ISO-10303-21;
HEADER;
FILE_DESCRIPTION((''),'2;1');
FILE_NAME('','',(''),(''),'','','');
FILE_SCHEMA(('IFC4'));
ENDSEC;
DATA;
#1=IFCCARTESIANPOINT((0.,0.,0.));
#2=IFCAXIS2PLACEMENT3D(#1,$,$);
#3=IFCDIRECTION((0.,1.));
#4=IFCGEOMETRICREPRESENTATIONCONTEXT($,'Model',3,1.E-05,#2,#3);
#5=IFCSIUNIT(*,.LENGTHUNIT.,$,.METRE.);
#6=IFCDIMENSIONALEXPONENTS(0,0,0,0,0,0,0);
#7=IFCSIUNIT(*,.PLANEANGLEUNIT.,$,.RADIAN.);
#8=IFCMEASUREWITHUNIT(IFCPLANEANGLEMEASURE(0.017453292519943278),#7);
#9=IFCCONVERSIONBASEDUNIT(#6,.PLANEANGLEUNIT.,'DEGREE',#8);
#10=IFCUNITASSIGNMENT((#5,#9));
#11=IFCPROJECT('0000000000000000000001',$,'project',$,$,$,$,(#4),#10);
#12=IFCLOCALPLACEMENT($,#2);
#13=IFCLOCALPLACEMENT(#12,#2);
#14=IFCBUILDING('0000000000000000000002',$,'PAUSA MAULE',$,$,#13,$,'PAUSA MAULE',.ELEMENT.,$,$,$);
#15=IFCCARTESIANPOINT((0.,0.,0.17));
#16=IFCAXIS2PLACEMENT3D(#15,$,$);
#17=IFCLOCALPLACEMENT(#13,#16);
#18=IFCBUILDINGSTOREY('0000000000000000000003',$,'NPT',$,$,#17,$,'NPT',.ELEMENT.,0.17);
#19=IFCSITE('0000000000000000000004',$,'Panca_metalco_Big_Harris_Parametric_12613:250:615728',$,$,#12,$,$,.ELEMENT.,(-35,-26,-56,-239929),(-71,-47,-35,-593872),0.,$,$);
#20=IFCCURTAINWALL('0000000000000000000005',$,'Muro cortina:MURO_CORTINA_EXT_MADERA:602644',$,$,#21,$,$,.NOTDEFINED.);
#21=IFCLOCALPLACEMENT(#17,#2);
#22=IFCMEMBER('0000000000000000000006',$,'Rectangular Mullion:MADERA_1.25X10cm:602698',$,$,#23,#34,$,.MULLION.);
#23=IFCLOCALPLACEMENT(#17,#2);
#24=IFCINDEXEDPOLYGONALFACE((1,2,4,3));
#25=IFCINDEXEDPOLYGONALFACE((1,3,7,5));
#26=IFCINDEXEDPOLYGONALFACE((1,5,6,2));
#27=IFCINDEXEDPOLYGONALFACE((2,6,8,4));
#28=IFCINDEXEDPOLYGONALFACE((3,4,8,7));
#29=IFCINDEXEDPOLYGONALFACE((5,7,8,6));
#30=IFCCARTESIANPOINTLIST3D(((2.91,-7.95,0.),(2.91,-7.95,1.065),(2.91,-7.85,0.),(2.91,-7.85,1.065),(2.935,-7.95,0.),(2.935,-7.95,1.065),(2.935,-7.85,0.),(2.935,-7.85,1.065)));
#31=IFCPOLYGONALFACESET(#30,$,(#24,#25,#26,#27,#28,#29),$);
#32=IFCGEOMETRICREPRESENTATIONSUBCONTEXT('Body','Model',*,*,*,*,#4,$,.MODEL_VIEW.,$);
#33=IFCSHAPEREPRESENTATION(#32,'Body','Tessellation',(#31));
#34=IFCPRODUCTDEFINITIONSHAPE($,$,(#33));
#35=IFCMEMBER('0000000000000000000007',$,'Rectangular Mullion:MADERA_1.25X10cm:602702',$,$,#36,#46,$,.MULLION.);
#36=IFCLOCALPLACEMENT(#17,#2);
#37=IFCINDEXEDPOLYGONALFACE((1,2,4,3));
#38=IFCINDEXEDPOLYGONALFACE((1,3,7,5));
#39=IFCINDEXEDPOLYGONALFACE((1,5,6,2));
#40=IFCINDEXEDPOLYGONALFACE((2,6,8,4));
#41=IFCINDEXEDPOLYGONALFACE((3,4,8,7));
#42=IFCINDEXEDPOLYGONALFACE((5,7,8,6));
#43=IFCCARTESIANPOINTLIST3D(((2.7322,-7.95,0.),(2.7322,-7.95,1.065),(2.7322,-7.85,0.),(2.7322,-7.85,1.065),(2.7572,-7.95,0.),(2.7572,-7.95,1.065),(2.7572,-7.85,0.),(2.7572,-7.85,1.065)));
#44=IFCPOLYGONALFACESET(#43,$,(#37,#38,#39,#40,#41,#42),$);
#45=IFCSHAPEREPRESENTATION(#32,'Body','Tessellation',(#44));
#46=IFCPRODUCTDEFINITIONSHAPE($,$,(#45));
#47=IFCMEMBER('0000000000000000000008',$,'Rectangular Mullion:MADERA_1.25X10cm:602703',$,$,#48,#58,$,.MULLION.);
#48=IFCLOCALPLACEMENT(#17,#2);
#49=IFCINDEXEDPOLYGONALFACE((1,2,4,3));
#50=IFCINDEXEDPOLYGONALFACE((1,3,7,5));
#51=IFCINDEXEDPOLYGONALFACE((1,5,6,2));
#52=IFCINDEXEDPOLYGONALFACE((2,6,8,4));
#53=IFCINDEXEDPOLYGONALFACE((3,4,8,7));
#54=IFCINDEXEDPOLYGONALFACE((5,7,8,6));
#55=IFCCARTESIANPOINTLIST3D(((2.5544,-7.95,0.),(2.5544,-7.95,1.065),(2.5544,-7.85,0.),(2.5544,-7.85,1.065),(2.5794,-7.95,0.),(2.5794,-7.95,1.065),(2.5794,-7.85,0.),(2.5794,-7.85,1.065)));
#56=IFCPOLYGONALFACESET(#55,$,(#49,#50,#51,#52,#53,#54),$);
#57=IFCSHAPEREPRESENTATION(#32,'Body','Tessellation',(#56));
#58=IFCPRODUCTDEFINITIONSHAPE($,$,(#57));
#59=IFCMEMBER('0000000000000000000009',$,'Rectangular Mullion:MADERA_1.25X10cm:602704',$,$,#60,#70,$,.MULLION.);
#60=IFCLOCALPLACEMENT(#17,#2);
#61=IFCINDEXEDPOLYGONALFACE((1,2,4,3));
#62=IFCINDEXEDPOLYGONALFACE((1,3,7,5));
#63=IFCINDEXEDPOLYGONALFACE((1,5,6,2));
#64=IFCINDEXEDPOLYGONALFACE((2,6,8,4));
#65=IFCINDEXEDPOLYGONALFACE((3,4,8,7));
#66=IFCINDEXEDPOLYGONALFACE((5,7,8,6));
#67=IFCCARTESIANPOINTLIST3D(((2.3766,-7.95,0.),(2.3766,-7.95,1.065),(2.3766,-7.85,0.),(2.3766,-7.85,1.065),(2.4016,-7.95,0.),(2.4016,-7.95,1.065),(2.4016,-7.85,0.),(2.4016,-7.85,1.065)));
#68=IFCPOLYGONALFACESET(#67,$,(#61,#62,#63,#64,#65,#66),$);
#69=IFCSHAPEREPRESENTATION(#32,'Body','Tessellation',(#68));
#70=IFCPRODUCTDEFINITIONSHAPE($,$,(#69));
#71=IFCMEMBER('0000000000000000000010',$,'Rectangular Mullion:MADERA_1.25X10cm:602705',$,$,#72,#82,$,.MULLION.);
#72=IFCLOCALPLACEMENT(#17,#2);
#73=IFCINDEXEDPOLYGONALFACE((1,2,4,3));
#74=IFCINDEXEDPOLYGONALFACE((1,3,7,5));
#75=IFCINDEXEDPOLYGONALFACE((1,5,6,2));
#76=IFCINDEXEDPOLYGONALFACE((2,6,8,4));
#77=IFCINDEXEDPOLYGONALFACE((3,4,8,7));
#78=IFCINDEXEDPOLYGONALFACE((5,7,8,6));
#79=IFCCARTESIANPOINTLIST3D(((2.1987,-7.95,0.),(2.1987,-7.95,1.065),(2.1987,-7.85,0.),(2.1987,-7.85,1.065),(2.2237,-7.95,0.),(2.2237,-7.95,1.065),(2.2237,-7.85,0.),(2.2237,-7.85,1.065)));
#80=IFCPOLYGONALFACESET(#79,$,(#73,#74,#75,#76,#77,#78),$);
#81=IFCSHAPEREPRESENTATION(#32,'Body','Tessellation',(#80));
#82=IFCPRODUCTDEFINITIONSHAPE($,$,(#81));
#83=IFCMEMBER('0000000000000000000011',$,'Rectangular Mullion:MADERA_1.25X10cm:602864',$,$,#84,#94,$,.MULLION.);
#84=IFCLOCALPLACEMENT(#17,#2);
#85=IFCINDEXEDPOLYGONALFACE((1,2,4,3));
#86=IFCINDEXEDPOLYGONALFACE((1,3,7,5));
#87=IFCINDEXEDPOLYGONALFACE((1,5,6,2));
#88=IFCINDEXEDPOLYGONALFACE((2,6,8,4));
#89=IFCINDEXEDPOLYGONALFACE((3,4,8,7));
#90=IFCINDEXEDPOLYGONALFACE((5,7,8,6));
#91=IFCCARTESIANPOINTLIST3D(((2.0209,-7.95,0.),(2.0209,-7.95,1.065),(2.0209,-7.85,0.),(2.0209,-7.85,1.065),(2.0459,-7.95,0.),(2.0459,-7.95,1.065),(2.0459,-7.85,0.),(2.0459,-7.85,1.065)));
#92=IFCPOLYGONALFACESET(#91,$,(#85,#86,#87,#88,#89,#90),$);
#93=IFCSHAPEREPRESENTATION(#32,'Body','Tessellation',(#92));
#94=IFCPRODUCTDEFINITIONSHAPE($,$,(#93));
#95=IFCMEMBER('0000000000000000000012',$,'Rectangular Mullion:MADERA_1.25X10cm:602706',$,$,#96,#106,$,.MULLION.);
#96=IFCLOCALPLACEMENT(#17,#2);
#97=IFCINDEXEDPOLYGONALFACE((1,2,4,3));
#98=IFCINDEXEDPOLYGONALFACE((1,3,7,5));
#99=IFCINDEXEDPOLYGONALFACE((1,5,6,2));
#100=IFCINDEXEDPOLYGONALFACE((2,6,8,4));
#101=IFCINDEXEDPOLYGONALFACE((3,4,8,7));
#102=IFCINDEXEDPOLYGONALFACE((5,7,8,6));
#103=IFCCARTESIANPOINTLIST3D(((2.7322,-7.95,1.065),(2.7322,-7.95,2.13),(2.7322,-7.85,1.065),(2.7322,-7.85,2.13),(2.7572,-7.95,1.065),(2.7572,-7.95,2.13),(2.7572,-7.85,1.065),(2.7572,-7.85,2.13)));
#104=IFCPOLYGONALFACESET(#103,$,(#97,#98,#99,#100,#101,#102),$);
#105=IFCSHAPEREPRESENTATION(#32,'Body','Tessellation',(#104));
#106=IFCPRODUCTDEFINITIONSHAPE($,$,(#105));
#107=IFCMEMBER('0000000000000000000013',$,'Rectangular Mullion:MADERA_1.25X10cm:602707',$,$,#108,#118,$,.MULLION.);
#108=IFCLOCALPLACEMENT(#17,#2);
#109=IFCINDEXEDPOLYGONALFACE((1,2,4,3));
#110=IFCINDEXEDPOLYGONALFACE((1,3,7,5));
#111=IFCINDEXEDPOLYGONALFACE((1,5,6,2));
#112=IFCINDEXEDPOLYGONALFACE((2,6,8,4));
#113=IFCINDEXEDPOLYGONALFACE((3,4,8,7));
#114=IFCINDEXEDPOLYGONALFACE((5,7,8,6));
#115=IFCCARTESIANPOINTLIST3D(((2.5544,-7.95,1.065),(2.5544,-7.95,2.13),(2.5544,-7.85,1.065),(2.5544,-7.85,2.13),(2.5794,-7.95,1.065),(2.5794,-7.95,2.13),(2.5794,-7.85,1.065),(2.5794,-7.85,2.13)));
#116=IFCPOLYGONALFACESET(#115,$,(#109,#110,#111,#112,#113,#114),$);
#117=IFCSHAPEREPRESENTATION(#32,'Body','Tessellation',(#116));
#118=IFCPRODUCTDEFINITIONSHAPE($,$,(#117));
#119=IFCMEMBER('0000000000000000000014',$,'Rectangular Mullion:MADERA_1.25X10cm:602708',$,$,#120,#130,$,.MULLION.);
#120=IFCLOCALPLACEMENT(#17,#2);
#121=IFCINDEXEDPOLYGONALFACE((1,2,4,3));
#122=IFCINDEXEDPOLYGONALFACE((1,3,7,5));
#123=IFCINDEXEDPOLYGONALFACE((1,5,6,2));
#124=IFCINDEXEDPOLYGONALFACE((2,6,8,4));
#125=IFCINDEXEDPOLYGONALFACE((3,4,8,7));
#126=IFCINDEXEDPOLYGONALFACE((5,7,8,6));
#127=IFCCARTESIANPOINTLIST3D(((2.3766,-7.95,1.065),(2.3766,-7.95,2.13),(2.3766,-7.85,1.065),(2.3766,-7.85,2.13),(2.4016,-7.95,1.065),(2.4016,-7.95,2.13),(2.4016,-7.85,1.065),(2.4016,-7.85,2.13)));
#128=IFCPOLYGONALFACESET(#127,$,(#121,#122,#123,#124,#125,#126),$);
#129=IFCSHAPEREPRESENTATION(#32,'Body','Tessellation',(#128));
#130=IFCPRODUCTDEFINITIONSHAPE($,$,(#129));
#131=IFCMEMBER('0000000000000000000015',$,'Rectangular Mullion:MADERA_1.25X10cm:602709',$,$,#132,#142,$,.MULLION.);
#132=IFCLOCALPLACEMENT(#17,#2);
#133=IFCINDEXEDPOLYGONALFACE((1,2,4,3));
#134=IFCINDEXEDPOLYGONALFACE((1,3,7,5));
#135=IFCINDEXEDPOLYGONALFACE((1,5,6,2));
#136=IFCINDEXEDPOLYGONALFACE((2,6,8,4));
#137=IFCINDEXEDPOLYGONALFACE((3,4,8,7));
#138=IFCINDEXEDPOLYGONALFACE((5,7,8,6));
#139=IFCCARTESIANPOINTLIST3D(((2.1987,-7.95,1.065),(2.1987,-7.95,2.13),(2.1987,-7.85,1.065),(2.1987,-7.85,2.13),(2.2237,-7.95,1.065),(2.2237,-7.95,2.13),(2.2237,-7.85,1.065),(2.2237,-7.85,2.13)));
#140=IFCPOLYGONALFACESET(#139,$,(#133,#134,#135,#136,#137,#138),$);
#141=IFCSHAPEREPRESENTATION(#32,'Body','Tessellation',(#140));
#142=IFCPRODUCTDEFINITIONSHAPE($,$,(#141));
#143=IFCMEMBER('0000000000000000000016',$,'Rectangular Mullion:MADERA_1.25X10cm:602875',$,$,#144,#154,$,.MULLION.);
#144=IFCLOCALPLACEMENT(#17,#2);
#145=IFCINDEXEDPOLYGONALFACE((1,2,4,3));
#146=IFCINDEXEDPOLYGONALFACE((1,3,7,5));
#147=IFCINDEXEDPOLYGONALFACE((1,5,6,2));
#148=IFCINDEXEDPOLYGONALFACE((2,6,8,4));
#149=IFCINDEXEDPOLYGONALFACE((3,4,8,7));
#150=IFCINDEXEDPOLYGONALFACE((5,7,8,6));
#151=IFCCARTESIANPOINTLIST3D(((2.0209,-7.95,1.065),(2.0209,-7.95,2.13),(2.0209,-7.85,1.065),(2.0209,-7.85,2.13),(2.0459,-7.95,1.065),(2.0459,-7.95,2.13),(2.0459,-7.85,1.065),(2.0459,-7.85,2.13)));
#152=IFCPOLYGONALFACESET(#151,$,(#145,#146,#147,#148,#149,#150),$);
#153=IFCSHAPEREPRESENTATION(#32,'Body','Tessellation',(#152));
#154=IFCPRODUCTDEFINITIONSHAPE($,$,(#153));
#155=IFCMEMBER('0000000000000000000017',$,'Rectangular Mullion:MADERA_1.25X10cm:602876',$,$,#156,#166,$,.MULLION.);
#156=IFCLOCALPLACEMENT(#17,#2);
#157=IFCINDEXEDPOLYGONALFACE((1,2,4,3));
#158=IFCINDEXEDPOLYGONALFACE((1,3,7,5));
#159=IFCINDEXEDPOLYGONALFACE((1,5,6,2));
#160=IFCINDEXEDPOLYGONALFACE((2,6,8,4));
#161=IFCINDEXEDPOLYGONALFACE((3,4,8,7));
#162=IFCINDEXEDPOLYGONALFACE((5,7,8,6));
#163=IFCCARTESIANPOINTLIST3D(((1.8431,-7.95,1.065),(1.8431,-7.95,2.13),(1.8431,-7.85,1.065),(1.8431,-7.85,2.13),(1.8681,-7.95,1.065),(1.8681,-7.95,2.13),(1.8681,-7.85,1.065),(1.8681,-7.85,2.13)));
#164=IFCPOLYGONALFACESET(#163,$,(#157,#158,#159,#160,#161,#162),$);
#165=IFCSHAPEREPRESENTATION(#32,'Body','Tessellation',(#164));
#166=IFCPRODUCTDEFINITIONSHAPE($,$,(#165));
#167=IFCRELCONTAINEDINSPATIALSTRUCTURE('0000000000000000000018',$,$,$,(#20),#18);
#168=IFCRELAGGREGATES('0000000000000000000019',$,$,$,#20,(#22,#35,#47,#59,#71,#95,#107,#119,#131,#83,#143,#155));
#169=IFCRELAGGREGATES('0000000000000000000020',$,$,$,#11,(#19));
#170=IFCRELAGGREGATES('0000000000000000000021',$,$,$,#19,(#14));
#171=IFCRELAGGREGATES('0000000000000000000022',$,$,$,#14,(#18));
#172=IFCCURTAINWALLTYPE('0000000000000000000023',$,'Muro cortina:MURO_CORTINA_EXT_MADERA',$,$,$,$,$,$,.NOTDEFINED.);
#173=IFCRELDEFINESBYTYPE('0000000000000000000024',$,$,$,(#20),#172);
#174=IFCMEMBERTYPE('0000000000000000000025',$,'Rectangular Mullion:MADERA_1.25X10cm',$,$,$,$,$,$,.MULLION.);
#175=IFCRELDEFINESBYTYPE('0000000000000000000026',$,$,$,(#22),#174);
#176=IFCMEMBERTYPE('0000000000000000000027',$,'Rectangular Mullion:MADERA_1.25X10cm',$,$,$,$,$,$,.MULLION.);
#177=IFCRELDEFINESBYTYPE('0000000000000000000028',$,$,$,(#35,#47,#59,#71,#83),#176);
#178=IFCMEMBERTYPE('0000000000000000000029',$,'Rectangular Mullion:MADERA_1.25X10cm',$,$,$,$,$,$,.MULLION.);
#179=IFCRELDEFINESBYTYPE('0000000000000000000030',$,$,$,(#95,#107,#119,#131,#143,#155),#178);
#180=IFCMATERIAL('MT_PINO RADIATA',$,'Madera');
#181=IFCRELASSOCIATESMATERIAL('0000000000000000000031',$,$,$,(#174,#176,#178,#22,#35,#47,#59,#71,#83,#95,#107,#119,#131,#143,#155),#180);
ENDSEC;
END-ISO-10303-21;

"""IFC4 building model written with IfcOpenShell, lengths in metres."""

from ifc_helpers import new_model, entity, si_unit, converted_unit, direction, frame, frame_2d, origin, place, context, subcontext, project, spatial, rectangle, extrude, source, transform, mapped, material, material_profile, profile_set, profile_usage, type_object, type_shapes, element, aggregate, save


model = new_model("IFC4")

# Units and contexts
model_context = context("Model", 3, precision=1e-05, world=origin(), true_north=direction((0.0, 1.0)))
body_context = subcontext(model_context, "Body", "Model", "MODEL_VIEW")
ifc_project = project(units=[si_unit("LENGTHUNIT", "METRE"), converted_unit("PLANEANGLEUNIT", "DEGREE", entity("IfcPlaneAngleMeasure", 0.017453292519943278), si_unit("PLANEANGLEUNIT", "RADIAN"), dimensions=[0, 0, 0, 0, 0, 0, 0])], contexts=[model_context])

# Site, building, storey
site_placement = place(None, origin())
site = spatial("IfcSite", under=ifc_project, at=site_placement, Name="Panca_metalco_Big_Harris_Parametric_12613:250:615728", CompositionType="ELEMENT", RefLatitude=(-35, -26, -56, -239929), RefLongitude=(-71, -47, -35, -593872), RefElevation=0.0)
building_placement = place(site_placement, origin())
building = spatial("IfcBuilding", under=site, at=building_placement, Name="PAUSA MAULE", LongName="PAUSA MAULE", CompositionType="ELEMENT")
storey_placement = place(building_placement, frame((0.0, 0.0, 0.17)))
storey = spatial("IfcBuildingStorey", under=building, at=storey_placement, Name="NPT", LongName="NPT", CompositionType="ELEMENT", Elevation=0.17)

# Curtain wall, members
curtain_wall_type = type_object("IfcCurtainWallType", Name="Muro cortina:MURO_CORTINA_EXT_MADERA", PredefinedType="NOTDEFINED")
curtain_wall_placement = place(storey_placement, frame((0.0, 0.0, -0.17)))
curtain_wall = element("IfcCurtainWall", 1, at=curtain_wall_placement, inside=storey, type_object=curtain_wall_type, Name="Muro cortina:MURO_CORTINA_EXT_MADERA:602644", PredefinedType="NOTDEFINED")
ifc_material = material(Name="MT_PINO RADIATA", Category="Madera")
ifc_material_profile = material_profile(ifc_material, rectangle(XDim=0.025, YDim=0.1, at=frame_2d((0.0, 0.0), x_axis=(1.0, 0.0))), Name="MADERA_1.25X10cm")
ifc_profile_set = profile_set([ifc_material_profile], Name="MADERA_1.25X10cm")
ifc_profile_usage = profile_usage(ifc_profile_set)
member_type_1 = type_object("IfcMemberType", Name="Rectangular Mullion:MADERA_1.25X10cm", PredefinedType="MULLION", material=ifc_profile_set)
shared_shape_1 = source(origin(), body_context, "Body", "SweptSolid", [
    extrude(rectangle(XDim=0.025, YDim=0.1, at=frame_2d((0.0, 0.0), x_axis=(1.0, 0.0))), frame((-0.0125, 0.0, -1.065), z_axis=(0.0, 0.0, 1.0), x_axis=(-1.0, 0.0, 0.0)), (0.0, 0.0, 1.0), 1.065),
])
type_shapes(member_type_1, [shared_shape_1])
member_1_placement = place(curtain_wall_placement, frame((2.935, -7.9, 1.235)))
member_1 = element("IfcMember", 2, at=member_1_placement, type_object=member_type_1, material=ifc_profile_usage, Name="Rectangular Mullion:MADERA_1.25X10cm:602698", PredefinedType="MULLION", context=body_context, shape_type="MappedRepresentation", body=[
    mapped(shared_shape_1, transform((0.0, 0.0, 0.0), scale=1.0)),
])
member_type_2 = type_object("IfcMemberType", Name="Rectangular Mullion:MADERA_1.25X10cm", PredefinedType="MULLION", material=ifc_profile_set)
shared_shape_2 = source(origin(), body_context, "Body", "SweptSolid", [
    extrude(rectangle(XDim=0.025, YDim=0.1, at=frame_2d((0.0, 0.0), x_axis=(1.0, 0.0))), frame((0.0, 0.0, -1.065), z_axis=(0.0, 0.0, 1.0), x_axis=(-1.0, 0.0, 0.0)), (0.0, 0.0, 1.0), 1.065),
])
type_shapes(member_type_2, [shared_shape_2])
member_2_placement = place(curtain_wall_placement, frame((2.7447, -7.9, 0.17), z_axis=(0.0, 0.0, -1.0), x_axis=(-1.0, 0.0, 0.0)))
member_2 = element("IfcMember", 3, at=member_2_placement, type_object=member_type_2, material=ifc_profile_usage, Name="Rectangular Mullion:MADERA_1.25X10cm:602702", PredefinedType="MULLION", context=body_context, shape_type="MappedRepresentation", body=[
    mapped(shared_shape_2, transform((0.0, 0.0, 0.0), scale=1.0)),
])
member_3_placement = place(curtain_wall_placement, frame((2.5669, -7.9, 0.17), z_axis=(0.0, 0.0, -1.0), x_axis=(-1.0, 0.0, 0.0)))
member_3 = element("IfcMember", 4, at=member_3_placement, type_object=member_type_2, material=ifc_profile_usage, Name="Rectangular Mullion:MADERA_1.25X10cm:602703", PredefinedType="MULLION", context=body_context, shape_type="MappedRepresentation", body=[
    mapped(shared_shape_2, transform((0.0, 0.0, 0.0), scale=1.0)),
])
member_4_placement = place(curtain_wall_placement, frame((2.3891, -7.9, 0.17), z_axis=(0.0, 0.0, -1.0), x_axis=(-1.0, 0.0, 0.0)))
member_4 = element("IfcMember", 5, at=member_4_placement, type_object=member_type_2, material=ifc_profile_usage, Name="Rectangular Mullion:MADERA_1.25X10cm:602704", PredefinedType="MULLION", context=body_context, shape_type="MappedRepresentation", body=[
    mapped(shared_shape_2, transform((0.0, 0.0, 0.0), scale=1.0)),
])
member_5_placement = place(curtain_wall_placement, frame((2.2112, -7.9, 0.17), z_axis=(0.0, 0.0, -1.0), x_axis=(-1.0, 0.0, 0.0)))
member_5 = element("IfcMember", 6, at=member_5_placement, type_object=member_type_2, material=ifc_profile_usage, Name="Rectangular Mullion:MADERA_1.25X10cm:602705", PredefinedType="MULLION", context=body_context, shape_type="MappedRepresentation", body=[
    mapped(shared_shape_2, transform((0.0, 0.0, 0.0), scale=1.0)),
])
member_6_placement = place(curtain_wall_placement, frame((2.0334, -7.9, 0.17), z_axis=(0.0, 0.0, -1.0), x_axis=(-1.0, 0.0, 0.0)))
member_6 = element("IfcMember", 7, at=member_6_placement, type_object=member_type_2, material=ifc_profile_usage, Name="Rectangular Mullion:MADERA_1.25X10cm:602864", PredefinedType="MULLION", context=body_context, shape_type="MappedRepresentation", body=[
    mapped(shared_shape_2, transform((0.0, 0.0, 0.0), scale=1.0)),
])
member_type_3 = type_object("IfcMemberType", Name="Rectangular Mullion:MADERA_1.25X10cm", PredefinedType="MULLION", material=ifc_profile_set)
shared_shape_3 = source(origin(), body_context, "Body", "SweptSolid", [
    extrude(rectangle(XDim=0.025, YDim=0.1, at=frame_2d((0.0, 0.0), x_axis=(1.0, 0.0))), frame((0.0, 0.0, -1.065), z_axis=(0.0, 0.0, 1.0), x_axis=(-1.0, 0.0, 0.0)), (0.0, 0.0, 1.0), 1.065),
])
type_shapes(member_type_3, [shared_shape_3])
member_7_placement = place(curtain_wall_placement, frame((2.7447, -7.9, 1.235), z_axis=(0.0, 0.0, -1.0), x_axis=(-1.0, 0.0, 0.0)))
member_7 = element("IfcMember", 8, at=member_7_placement, type_object=member_type_3, material=ifc_profile_usage, Name="Rectangular Mullion:MADERA_1.25X10cm:602706", PredefinedType="MULLION", context=body_context, shape_type="MappedRepresentation", body=[
    mapped(shared_shape_3, transform((0.0, 0.0, 0.0), scale=1.0)),
])
member_8_placement = place(curtain_wall_placement, frame((2.5669, -7.9, 1.235), z_axis=(0.0, 0.0, -1.0), x_axis=(-1.0, 0.0, 0.0)))
member_8 = element("IfcMember", 9, at=member_8_placement, type_object=member_type_3, material=ifc_profile_usage, Name="Rectangular Mullion:MADERA_1.25X10cm:602707", PredefinedType="MULLION", context=body_context, shape_type="MappedRepresentation", body=[
    mapped(shared_shape_3, transform((0.0, 0.0, 0.0), scale=1.0)),
])
member_9_placement = place(curtain_wall_placement, frame((2.3891, -7.9, 1.235), z_axis=(0.0, 0.0, -1.0), x_axis=(-1.0, 0.0, 0.0)))
member_9 = element("IfcMember", 10, at=member_9_placement, type_object=member_type_3, material=ifc_profile_usage, Name="Rectangular Mullion:MADERA_1.25X10cm:602708", PredefinedType="MULLION", context=body_context, shape_type="MappedRepresentation", body=[
    mapped(shared_shape_3, transform((0.0, 0.0, 0.0), scale=1.0)),
])
member_10_placement = place(curtain_wall_placement, frame((2.2112, -7.9, 1.235), z_axis=(0.0, 0.0, -1.0), x_axis=(-1.0, 0.0, 0.0)))
member_10 = element("IfcMember", 11, at=member_10_placement, type_object=member_type_3, material=ifc_profile_usage, Name="Rectangular Mullion:MADERA_1.25X10cm:602709", PredefinedType="MULLION", context=body_context, shape_type="MappedRepresentation", body=[
    mapped(shared_shape_3, transform((0.0, 0.0, 0.0), scale=1.0)),
])
member_11_placement = place(curtain_wall_placement, frame((2.0334, -7.9, 1.235), z_axis=(0.0, 0.0, -1.0), x_axis=(-1.0, 0.0, 0.0)))
member_11 = element("IfcMember", 12, at=member_11_placement, type_object=member_type_3, material=ifc_profile_usage, Name="Rectangular Mullion:MADERA_1.25X10cm:602875", PredefinedType="MULLION", context=body_context, shape_type="MappedRepresentation", body=[
    mapped(shared_shape_3, transform((0.0, 0.0, 0.0), scale=1.0)),
])
member_12_placement = place(curtain_wall_placement, frame((1.8556, -7.9, 1.235), z_axis=(0.0, 0.0, -1.0), x_axis=(-1.0, 0.0, 0.0)))
member_12 = element("IfcMember", 13, at=member_12_placement, type_object=member_type_3, material=ifc_profile_usage, Name="Rectangular Mullion:MADERA_1.25X10cm:602876", PredefinedType="MULLION", context=body_context, shape_type="MappedRepresentation", body=[
    mapped(shared_shape_3, transform((0.0, 0.0, 0.0), scale=1.0)),
])
aggregate(curtain_wall, [member_1, member_2, member_3, member_4, member_5, member_7, member_8, member_9, member_10, member_6, member_11, member_12])

save(model, "model.ifc")
